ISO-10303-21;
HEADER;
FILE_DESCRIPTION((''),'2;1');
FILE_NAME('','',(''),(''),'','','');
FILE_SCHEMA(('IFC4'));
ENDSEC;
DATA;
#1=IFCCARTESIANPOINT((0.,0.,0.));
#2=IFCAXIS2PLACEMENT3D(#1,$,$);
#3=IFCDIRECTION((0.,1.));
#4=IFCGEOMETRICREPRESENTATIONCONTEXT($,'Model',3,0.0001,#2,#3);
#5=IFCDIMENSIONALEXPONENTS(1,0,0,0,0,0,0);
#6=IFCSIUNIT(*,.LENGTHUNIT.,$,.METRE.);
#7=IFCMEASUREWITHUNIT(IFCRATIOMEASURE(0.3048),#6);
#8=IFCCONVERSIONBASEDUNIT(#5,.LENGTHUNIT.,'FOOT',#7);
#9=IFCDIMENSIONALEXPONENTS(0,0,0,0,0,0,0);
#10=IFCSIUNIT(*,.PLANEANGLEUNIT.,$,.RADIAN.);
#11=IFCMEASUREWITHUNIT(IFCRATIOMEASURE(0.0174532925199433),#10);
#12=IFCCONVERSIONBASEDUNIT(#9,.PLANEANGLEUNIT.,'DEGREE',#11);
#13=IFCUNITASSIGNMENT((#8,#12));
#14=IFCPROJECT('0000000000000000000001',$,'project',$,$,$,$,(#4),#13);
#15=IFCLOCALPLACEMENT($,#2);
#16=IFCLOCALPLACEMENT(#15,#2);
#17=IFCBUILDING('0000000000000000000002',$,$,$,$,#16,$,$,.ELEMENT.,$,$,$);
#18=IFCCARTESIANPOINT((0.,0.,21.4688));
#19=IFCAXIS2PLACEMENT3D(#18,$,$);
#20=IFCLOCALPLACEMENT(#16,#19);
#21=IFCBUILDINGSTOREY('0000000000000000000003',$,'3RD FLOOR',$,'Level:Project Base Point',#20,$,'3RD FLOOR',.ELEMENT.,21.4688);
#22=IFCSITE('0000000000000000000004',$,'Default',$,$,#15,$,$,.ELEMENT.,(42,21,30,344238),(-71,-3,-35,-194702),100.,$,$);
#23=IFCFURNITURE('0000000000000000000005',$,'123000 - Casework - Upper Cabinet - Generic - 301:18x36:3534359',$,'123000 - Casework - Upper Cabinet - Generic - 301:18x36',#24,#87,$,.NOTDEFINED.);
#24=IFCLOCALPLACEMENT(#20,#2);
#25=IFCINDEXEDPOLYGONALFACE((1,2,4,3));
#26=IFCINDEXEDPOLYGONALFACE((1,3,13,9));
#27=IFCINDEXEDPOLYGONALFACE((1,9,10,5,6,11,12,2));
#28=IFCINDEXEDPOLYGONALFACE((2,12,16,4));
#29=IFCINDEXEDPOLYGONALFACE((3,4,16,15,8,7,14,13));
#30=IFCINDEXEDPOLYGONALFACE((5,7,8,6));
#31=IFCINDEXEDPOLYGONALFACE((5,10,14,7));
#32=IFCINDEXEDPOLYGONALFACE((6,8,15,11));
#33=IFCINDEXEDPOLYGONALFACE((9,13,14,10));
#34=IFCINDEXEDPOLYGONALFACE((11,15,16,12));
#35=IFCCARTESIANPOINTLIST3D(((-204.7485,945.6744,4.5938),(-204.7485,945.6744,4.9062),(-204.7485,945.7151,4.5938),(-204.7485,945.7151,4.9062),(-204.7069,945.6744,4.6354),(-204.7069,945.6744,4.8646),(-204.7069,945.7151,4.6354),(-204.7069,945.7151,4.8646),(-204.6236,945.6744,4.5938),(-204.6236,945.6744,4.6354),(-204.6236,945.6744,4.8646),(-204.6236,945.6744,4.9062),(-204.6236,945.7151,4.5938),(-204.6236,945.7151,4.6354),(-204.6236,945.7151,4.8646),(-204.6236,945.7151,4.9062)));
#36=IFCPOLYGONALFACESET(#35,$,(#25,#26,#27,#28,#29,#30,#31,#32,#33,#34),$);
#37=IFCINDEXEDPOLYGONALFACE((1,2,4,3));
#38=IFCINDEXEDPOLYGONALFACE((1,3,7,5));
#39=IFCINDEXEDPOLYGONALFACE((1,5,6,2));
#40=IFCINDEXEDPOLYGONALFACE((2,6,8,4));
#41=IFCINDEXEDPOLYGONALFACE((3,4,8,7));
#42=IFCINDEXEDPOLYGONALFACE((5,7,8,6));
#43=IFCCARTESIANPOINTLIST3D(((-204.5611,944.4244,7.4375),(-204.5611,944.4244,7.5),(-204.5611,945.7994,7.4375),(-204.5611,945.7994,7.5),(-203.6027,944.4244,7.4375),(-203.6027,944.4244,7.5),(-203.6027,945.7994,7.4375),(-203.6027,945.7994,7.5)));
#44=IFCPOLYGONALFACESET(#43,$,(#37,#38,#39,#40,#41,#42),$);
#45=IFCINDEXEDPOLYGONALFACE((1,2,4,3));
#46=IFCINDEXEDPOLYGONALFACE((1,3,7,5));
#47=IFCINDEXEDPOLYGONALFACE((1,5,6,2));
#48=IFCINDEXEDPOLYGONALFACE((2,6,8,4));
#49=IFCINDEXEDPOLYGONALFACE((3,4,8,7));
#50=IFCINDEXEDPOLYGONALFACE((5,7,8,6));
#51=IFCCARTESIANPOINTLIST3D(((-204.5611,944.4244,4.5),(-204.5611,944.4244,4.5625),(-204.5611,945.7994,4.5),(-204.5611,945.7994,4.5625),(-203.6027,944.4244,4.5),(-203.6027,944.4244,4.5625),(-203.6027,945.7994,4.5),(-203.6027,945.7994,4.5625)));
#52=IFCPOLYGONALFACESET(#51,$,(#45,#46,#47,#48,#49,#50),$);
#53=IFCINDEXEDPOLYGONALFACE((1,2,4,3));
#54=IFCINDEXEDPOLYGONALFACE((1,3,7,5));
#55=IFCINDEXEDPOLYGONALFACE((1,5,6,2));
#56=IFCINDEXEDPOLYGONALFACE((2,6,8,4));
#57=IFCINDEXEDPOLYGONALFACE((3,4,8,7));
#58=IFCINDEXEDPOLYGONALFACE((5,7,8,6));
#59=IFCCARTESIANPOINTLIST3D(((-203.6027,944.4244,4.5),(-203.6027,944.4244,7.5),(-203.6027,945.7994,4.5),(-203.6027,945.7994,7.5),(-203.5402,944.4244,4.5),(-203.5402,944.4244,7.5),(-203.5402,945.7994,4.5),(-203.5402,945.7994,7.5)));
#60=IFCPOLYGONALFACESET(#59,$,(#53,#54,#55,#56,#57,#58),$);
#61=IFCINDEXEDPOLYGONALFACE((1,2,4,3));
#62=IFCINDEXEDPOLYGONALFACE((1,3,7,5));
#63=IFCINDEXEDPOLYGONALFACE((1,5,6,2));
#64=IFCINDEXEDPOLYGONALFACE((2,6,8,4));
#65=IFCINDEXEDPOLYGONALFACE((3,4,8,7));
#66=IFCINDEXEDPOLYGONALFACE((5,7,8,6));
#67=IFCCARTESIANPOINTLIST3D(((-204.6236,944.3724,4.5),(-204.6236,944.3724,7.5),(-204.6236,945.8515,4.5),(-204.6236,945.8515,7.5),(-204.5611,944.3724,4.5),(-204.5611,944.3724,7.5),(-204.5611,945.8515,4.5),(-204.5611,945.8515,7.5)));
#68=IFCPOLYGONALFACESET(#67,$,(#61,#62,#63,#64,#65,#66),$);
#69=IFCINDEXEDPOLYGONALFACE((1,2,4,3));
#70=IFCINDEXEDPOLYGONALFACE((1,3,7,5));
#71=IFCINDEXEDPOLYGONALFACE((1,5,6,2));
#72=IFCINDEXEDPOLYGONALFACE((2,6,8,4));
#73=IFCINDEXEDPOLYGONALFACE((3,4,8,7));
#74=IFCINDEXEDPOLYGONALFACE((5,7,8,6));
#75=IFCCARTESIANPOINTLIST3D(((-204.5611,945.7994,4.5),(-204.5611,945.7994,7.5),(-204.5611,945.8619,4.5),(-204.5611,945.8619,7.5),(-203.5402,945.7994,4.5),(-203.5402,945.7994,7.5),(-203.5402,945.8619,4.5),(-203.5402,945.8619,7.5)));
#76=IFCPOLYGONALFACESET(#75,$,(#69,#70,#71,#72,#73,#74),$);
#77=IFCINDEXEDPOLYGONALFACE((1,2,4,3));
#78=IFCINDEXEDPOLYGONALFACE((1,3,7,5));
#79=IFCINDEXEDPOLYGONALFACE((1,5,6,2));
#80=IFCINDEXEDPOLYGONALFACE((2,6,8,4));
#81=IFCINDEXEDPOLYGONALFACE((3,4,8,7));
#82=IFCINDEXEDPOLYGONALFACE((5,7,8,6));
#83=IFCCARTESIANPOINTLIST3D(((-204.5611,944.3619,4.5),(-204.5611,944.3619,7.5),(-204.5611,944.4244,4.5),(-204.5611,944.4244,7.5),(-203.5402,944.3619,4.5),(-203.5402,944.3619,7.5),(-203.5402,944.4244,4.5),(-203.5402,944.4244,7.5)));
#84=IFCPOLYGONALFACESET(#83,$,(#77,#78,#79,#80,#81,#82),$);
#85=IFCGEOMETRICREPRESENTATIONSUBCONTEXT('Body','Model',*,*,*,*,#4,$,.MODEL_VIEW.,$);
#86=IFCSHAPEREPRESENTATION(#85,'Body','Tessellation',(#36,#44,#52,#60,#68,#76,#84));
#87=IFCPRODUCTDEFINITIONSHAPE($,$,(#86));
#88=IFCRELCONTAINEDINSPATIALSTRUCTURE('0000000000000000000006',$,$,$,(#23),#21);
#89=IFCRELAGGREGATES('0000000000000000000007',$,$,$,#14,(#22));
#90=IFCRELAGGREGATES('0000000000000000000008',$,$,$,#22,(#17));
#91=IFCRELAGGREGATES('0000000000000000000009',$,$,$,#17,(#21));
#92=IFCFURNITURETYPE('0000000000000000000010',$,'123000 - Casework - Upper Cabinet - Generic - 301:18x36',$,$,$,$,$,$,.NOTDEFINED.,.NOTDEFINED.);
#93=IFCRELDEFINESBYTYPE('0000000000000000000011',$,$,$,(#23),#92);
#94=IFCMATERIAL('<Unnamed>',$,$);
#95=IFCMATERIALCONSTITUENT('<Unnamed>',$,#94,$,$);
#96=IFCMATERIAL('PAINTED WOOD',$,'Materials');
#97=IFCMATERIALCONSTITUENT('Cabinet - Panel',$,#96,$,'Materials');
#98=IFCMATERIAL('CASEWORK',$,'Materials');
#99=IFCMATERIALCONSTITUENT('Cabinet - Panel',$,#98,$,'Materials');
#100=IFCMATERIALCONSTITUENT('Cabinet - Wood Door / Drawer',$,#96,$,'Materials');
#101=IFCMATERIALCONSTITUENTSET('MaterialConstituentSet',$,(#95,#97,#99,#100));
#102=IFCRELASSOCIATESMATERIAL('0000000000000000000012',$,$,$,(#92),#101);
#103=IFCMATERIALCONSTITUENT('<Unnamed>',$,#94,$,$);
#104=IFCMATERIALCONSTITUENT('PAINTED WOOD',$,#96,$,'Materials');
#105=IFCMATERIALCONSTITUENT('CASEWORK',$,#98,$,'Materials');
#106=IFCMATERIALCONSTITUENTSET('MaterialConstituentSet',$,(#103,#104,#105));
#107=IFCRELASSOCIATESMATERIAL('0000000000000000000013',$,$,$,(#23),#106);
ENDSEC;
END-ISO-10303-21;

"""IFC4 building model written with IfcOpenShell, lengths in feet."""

from ifc_helpers import new_model, entity, si_unit, converted_unit, direction, frame, frame_2d, origin, origin_2d_with_axis, place, context, subcontext, project, spatial, polyline, rectangle, outline, extrude, source, transform, mapped, material, constituent, constituent_set, type_object, type_shapes, element, save


model = new_model("IFC4")

# Units and contexts
model_context = context("Model", 3, precision=0.0001, world=origin(), true_north=direction((0.0, 1.0)))
body_context = subcontext(model_context, "Body", "Model", "MODEL_VIEW")
ifc_project = project(units=[converted_unit("LENGTHUNIT", "FOOT", entity("IfcRatioMeasure", 0.3048), si_unit("LENGTHUNIT", "METRE"), dimensions=[1, 0, 0, 0, 0, 0, 0]), converted_unit("PLANEANGLEUNIT", "DEGREE", entity("IfcRatioMeasure", 0.0174532925199433), si_unit("PLANEANGLEUNIT", "RADIAN"), dimensions=[0, 0, 0, 0, 0, 0, 0])], contexts=[model_context])

# Site, building, storey
site_placement = place(None, origin())
site = spatial("IfcSite", under=ifc_project, at=site_placement, Name="Default", CompositionType="ELEMENT", RefLatitude=(42, 21, 30, 344238), RefLongitude=(-71, -3, -35, -194702), RefElevation=100.0)
building_placement = place(site_placement, origin())
building = spatial("IfcBuilding", under=site, at=building_placement, CompositionType="ELEMENT")
storey_placement = place(building_placement, frame((0.0, 0.0, 21.4688)))
storey = spatial("IfcBuildingStorey", under=building, at=storey_placement, Name="3RD FLOOR", ObjectType="Level:Project Base Point", LongName="3RD FLOOR", CompositionType="ELEMENT", Elevation=21.4688)

# Furniture
ifc_material_1 = material(Name="CASEWORK", Category="Materials")
ifc_material_2 = material(Name="<Unnamed>")
ifc_material_3 = material(Name="PAINTED WOOD", Category="Materials")
ifc_constituent_1 = constituent(ifc_material_2, Name="<Unnamed>")
ifc_constituent_2 = constituent(ifc_material_3, Name="PAINTED WOOD", Category="Materials")
ifc_constituent_3 = constituent(ifc_material_1, Name="CASEWORK", Category="Materials")
ifc_constituent_set_1 = constituent_set(constituents=[ifc_constituent_1, ifc_constituent_2, ifc_constituent_3], Name="MaterialConstituentSet")
ifc_constituent_4 = constituent(ifc_material_2, Name="<Unnamed>")
ifc_constituent_5 = constituent(ifc_material_3, Name="Cabinet - Panel", Category="Materials")
ifc_constituent_6 = constituent(ifc_material_1, Name="Cabinet - Panel", Category="Materials")
ifc_constituent_7 = constituent(ifc_material_3, Name="Cabinet - Wood Door / Drawer", Category="Materials")
ifc_constituent_set_2 = constituent_set(constituents=[ifc_constituent_4, ifc_constituent_5, ifc_constituent_6, ifc_constituent_7], Name="MaterialConstituentSet")
furniture_type_1 = type_object("IfcFurnitureType", Name="123000 - Casework - Upper Cabinet - Generic - 301:18x36", AssemblyPlace="NOTDEFINED", PredefinedType="NOTDEFINED", material=ifc_constituent_set_2)
shared_shape_1 = source(origin(), body_context, "Body", "SweptSolid", [
    extrude(outline(polyline([(0.1146, -0.0521), (0.1562, -0.0521), (0.1562, 0.0729), (-0.1562, 0.0729), (-0.1562, -0.0521), (-0.1146, -0.0521), (-0.1146, 0.0313), (0.1146, 0.0313), (0.1146, -0.0521)])), frame((0.1468, 0.0729, 0.25), z_axis=(1.0, 0.0, 0.0), x_axis=(0.0, 0.0, 1.0)), (0.0, 0.0, 1.0), 0.0407),
    extrude(rectangle(XDim=1.375, YDim=0.9583, at=frame_2d((0.0, 0.0), x_axis=(1.0, 0.0))), frame((0.75, 0.6666, 2.9375), z_axis=(0.0, 0.0, 1.0), x_axis=(-1.0, 0.0, 0.0)), (0.0, 0.0, 1.0), 0.0625),
    extrude(rectangle(XDim=1.375, YDim=0.9583, at=frame_2d((0.0, 0.0), x_axis=(1.0, 0.0))), frame((0.75, 0.6666, 0.0), z_axis=(0.0, 0.0, 1.0), x_axis=(-1.0, 0.0, 0.0)), (0.0, 0.0, 1.0), 0.0625),
    extrude(rectangle(XDim=0.0625, YDim=1.375, at=origin_2d_with_axis()), frame((0.75, 1.177, 0.0), z_axis=(0.0, 0.0, 1.0), x_axis=(0.0, 1.0, 0.0)), (0.0, 0.0, 1.0), 3.0),
    extrude(rectangle(XDim=0.0625, YDim=1.4792, at=origin_2d_with_axis()), frame((0.75, 0.1562, 0.0), z_axis=(0.0, 0.0, 1.0), x_axis=(0.0, -1.0, 0.0)), (0.0, 0.0, 1.0), 3.0),
    extrude(rectangle(XDim=0.0625, YDim=1.0208, at=origin_2d_with_axis()), frame((0.0312, 0.6979, 0.0), z_axis=(0.0, 0.0, 1.0), x_axis=(-1.0, 0.0, 0.0)), (0.0, 0.0, 1.0), 3.0),
    extrude(rectangle(XDim=0.0625, YDim=1.0208, at=origin_2d_with_axis()), frame((1.4688, 0.6979, 0.0), z_axis=(0.0, 0.0, 1.0), x_axis=(-1.0, 0.0, 0.0)), (0.0, 0.0, 1.0), 3.0),
])
type_shapes(furniture_type_1, [shared_shape_1])
furniture_1_placement = place(storey_placement, frame((-204.7485, 945.8619, 4.5), z_axis=(0.0, 0.0, 1.0), x_axis=(0.0, -1.0, 0.0)))
element("IfcFurniture", 1, at=furniture_1_placement, inside=storey, type_object=furniture_type_1, material=ifc_constituent_set_1, Name="123000 - Casework - Upper Cabinet - Generic - 301:18x36:3534359", ObjectType="123000 - Casework - Upper Cabinet - Generic - 301:18x36", PredefinedType="NOTDEFINED", context=body_context, shape_type="MappedRepresentation", body=[
    mapped(shared_shape_1, transform((0.0, 0.0, 0.0), scale=1.0)),
])

save(model, "model.ifc")
